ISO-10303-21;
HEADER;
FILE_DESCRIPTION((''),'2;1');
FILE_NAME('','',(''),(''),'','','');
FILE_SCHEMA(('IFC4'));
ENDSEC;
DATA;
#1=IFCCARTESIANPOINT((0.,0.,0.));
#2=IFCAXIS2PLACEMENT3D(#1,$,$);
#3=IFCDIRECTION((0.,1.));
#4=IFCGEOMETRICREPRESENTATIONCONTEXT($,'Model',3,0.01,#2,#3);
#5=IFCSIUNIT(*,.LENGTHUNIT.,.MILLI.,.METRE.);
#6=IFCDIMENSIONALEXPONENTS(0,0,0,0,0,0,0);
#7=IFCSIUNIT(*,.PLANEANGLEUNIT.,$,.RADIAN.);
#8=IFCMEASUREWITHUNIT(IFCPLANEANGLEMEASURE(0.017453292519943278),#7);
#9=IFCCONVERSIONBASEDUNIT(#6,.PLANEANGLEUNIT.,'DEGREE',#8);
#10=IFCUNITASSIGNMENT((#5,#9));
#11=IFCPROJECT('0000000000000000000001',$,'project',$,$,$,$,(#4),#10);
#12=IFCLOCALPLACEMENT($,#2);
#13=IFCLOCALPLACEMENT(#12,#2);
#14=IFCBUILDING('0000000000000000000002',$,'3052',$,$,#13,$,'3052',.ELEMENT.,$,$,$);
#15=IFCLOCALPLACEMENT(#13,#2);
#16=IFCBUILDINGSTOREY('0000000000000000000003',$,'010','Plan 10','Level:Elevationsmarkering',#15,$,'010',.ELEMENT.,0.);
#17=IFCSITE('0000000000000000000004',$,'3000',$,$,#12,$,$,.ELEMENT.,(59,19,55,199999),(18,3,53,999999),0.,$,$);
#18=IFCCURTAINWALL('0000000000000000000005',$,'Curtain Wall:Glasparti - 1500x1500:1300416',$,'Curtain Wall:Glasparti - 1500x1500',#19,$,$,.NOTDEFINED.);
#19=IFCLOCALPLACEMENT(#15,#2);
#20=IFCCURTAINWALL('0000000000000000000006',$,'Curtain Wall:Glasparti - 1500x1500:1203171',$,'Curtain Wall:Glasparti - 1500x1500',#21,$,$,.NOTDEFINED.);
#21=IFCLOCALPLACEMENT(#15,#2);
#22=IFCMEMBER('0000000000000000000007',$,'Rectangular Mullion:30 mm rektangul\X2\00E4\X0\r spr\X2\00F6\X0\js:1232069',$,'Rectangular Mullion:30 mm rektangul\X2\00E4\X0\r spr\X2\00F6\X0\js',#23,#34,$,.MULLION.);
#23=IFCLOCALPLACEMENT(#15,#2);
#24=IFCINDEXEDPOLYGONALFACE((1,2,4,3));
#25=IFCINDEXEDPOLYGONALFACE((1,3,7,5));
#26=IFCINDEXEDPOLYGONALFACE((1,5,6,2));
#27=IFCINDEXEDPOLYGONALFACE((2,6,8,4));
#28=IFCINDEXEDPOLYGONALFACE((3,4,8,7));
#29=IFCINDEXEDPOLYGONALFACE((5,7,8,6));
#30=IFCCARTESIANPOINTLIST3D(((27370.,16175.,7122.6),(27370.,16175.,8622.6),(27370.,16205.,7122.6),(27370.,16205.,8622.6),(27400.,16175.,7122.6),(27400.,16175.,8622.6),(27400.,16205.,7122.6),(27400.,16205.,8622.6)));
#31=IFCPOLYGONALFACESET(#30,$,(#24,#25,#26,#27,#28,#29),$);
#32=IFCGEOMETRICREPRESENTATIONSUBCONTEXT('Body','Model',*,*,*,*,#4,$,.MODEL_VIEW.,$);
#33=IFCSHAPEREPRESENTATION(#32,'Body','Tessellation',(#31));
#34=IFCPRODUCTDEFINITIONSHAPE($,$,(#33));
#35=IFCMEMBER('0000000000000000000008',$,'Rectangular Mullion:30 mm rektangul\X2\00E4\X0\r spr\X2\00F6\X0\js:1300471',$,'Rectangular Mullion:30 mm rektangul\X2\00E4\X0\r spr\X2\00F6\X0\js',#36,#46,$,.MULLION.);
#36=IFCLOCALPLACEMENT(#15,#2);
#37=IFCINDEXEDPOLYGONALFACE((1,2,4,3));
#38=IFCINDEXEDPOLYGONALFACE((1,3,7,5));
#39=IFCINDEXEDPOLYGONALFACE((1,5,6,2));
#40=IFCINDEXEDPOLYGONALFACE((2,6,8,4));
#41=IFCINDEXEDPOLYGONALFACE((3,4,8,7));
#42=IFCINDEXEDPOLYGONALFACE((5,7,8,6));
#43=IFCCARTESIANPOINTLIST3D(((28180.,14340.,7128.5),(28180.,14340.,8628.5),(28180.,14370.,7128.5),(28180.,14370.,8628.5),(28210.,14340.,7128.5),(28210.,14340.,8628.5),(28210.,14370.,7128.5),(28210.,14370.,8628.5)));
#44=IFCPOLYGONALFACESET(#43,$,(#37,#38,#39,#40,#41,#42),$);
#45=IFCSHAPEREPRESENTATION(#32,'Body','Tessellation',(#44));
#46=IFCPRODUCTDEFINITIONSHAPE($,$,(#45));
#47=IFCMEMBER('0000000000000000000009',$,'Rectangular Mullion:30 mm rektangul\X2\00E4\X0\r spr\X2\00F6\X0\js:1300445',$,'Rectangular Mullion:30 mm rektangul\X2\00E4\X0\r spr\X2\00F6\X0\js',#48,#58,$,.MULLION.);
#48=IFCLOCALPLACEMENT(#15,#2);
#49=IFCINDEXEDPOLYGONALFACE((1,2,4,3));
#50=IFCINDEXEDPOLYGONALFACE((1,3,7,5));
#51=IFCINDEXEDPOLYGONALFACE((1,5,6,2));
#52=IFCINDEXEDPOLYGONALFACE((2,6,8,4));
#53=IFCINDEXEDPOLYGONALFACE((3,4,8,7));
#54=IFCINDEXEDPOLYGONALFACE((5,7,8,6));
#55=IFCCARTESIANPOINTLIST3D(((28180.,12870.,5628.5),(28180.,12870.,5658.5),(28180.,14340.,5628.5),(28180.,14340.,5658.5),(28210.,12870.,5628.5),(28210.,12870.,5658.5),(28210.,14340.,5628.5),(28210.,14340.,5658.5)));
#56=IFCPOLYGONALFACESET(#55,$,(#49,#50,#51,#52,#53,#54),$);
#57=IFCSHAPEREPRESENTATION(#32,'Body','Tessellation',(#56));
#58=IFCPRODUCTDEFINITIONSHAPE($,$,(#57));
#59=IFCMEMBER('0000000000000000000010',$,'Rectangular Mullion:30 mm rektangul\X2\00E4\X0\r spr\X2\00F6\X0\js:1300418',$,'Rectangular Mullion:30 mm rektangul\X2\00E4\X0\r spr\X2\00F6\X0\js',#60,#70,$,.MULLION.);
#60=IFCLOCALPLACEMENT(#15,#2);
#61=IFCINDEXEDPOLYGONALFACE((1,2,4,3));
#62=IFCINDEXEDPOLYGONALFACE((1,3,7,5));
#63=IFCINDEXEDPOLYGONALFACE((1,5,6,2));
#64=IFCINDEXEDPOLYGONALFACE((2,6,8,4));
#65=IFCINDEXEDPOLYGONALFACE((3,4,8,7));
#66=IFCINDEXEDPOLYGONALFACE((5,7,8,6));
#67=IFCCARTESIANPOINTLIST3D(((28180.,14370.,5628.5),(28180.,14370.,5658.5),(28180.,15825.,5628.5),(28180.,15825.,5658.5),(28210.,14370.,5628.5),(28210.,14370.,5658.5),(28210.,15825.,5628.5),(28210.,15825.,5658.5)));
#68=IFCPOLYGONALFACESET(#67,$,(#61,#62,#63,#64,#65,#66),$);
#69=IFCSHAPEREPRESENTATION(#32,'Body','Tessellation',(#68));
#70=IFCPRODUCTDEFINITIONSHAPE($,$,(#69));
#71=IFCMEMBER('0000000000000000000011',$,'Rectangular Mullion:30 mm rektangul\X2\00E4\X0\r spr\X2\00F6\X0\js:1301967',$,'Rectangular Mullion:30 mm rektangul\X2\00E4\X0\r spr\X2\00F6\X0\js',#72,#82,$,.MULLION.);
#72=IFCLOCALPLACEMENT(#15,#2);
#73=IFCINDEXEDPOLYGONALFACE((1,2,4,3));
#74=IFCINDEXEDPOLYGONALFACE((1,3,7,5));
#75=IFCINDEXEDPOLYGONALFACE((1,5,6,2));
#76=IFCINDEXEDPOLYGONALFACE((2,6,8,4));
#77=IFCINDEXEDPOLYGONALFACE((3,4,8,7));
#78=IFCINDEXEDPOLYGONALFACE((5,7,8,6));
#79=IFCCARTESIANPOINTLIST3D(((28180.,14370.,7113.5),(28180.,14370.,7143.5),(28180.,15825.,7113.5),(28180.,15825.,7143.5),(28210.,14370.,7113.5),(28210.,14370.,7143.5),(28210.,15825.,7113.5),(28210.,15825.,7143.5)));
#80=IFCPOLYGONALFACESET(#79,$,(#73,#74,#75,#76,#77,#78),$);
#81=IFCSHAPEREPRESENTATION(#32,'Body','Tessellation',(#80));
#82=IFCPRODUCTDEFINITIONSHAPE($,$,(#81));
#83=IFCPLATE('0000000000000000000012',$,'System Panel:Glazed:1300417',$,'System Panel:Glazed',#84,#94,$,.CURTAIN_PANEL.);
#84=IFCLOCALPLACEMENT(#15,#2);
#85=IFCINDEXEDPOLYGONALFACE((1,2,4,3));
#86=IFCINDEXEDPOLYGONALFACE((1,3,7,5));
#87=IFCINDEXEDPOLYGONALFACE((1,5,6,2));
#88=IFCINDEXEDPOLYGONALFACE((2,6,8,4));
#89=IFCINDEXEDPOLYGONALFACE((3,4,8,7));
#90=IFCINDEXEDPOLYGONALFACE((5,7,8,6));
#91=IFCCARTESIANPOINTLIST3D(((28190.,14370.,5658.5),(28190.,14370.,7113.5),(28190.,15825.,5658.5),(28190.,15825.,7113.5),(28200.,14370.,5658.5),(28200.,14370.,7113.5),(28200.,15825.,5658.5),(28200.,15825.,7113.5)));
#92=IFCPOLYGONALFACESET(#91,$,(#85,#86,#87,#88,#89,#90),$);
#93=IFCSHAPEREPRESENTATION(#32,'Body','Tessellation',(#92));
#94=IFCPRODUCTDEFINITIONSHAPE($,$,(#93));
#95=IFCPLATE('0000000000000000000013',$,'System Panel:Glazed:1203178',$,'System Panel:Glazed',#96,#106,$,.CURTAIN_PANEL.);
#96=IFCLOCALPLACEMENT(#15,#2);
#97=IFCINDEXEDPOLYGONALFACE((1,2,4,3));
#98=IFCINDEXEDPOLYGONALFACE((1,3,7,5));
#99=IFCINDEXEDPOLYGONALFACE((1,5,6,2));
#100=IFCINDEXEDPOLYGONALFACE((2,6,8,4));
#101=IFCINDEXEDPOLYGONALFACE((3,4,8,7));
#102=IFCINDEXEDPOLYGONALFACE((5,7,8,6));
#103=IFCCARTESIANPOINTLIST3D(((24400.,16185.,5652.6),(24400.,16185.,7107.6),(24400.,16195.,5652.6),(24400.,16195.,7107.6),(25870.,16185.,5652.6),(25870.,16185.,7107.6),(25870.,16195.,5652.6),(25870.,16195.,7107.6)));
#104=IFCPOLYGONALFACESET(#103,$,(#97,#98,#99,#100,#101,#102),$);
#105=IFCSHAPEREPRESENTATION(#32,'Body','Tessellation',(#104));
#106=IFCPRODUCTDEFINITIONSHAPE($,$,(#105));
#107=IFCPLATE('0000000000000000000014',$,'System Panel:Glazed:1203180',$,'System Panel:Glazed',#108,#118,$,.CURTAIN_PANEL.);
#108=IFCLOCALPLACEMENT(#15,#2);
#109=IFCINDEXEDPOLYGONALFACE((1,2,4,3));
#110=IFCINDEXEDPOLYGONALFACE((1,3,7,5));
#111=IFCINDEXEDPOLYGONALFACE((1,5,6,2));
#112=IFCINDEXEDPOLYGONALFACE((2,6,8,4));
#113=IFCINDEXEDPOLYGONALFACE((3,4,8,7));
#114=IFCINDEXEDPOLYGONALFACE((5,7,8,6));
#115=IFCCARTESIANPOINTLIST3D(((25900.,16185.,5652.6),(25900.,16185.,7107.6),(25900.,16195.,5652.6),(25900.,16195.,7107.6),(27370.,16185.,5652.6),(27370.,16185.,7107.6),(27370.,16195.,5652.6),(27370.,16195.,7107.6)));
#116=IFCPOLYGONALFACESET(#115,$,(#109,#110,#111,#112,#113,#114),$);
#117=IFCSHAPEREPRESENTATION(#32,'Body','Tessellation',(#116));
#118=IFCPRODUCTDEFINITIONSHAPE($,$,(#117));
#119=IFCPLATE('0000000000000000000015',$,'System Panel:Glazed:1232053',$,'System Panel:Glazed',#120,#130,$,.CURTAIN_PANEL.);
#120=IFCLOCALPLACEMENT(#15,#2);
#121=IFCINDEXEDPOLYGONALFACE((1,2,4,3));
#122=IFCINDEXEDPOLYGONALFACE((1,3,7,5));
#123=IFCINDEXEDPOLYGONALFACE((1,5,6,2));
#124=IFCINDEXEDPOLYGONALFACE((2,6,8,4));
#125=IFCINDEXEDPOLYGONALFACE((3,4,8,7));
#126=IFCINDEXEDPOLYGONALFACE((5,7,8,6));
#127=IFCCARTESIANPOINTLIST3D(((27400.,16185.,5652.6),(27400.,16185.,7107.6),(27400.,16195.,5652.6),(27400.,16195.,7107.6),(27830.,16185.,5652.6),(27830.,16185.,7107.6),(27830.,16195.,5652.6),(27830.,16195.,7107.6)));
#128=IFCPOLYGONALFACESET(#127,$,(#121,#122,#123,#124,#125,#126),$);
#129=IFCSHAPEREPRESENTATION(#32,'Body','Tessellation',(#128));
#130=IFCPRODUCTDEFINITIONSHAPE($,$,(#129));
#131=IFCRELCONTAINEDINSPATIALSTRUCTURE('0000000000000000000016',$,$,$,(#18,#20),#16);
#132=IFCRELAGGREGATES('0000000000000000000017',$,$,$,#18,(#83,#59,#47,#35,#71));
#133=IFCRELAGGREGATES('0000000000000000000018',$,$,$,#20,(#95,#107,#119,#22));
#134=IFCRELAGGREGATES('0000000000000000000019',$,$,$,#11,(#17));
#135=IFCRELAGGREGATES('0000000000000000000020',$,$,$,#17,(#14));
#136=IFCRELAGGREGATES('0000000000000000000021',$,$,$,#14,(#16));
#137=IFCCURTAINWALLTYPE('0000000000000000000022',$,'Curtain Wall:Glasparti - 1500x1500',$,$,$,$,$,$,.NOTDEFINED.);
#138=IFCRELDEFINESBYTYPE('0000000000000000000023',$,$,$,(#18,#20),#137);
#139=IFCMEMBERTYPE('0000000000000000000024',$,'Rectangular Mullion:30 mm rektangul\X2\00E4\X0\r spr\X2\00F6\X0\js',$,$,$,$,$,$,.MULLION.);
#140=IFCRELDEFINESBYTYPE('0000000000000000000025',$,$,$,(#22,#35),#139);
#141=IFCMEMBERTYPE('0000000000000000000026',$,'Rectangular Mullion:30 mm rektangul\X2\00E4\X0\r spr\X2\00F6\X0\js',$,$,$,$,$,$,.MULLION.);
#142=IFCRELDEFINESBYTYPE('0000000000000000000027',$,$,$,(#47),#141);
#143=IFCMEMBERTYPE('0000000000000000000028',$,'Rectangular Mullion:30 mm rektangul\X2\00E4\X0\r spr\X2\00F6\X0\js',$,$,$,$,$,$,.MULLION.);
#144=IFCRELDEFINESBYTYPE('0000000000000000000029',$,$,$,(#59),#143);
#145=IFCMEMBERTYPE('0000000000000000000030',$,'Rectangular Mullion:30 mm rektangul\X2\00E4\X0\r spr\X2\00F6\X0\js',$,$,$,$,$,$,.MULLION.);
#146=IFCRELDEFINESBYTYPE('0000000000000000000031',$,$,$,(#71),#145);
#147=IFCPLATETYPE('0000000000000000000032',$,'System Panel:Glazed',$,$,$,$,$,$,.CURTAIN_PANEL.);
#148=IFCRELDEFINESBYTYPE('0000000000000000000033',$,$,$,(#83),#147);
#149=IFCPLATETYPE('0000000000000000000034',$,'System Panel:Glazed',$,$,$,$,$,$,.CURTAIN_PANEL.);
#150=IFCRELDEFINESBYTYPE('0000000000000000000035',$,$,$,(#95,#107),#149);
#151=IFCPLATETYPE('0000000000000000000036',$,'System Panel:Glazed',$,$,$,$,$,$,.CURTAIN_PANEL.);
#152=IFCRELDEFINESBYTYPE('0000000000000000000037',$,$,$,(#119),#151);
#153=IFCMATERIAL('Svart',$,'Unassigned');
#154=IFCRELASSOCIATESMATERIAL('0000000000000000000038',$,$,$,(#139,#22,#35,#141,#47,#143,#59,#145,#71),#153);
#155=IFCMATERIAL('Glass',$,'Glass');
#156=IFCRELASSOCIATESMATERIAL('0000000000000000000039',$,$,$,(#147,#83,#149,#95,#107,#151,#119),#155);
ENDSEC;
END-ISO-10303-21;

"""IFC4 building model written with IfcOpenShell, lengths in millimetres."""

from ifc_helpers import new_model, entity, si_unit, converted_unit, direction, frame, origin, place, context, subcontext, project, spatial, indexed_curve, outline, extrude, source, transform, mapped, material, type_object, type_shapes, element, aggregate, save


model = new_model("IFC4")

# Units and contexts
model_context = context("Model", 3, precision=0.01, world=origin(), true_north=direction((0.0, 1.0)))
body_context = subcontext(model_context, "Body", "Model", "MODEL_VIEW")
ifc_project = project(units=[si_unit("LENGTHUNIT", "METRE", prefix="MILLI"), converted_unit("PLANEANGLEUNIT", "DEGREE", entity("IfcPlaneAngleMeasure", 0.017453292519943278), si_unit("PLANEANGLEUNIT", "RADIAN"), dimensions=[0, 0, 0, 0, 0, 0, 0])], contexts=[model_context])

# Site, building, storey
site_placement = place(None, origin())
site = spatial("IfcSite", under=ifc_project, at=site_placement, Name="3000", CompositionType="ELEMENT", RefLatitude=(59, 19, 55, 199999), RefLongitude=(18, 3, 53, 999999), RefElevation=0.0)
building_placement = place(site_placement, origin())
building = spatial("IfcBuilding", under=site, at=building_placement, Name="3052", LongName="3052", CompositionType="ELEMENT")
storey_placement = place(building_placement, origin())
storey = spatial("IfcBuildingStorey", under=building, at=storey_placement, Name="010", Description="Plan 10", ObjectType="Level:Elevationsmarkering", LongName="010", CompositionType="ELEMENT", Elevation=0.0)

# Curtain wall
curtain_wall_type = type_object("IfcCurtainWallType", Name="Curtain Wall:Glasparti - 1500x1500", PredefinedType="NOTDEFINED")
curtain_wall_1_placement = place(storey_placement, origin())
curtain_wall_1 = element("IfcCurtainWall", 1, at=curtain_wall_1_placement, inside=storey, type_object=curtain_wall_type, Name="Curtain Wall:Glasparti - 1500x1500:1300416", ObjectType="Curtain Wall:Glasparti - 1500x1500", PredefinedType="NOTDEFINED")
ifc_material_1 = material(Name="Svart", Category="Unassigned")

# Curtain wall
curtain_wall_2_placement = place(storey_placement, origin())
curtain_wall_2 = element("IfcCurtainWall", 2, at=curtain_wall_2_placement, inside=storey, type_object=curtain_wall_type, Name="Curtain Wall:Glasparti - 1500x1500:1203171", ObjectType="Curtain Wall:Glasparti - 1500x1500", PredefinedType="NOTDEFINED")

# Members
member_type_1 = type_object("IfcMemberType", Name="Rectangular Mullion:30 mm rektangulär spröjs", PredefinedType="MULLION", material=ifc_material_1)
shared_shape_1 = source(origin(), body_context, "Body", "SweptSolid", [
    extrude(outline(indexed_curve([(-15.0, -15.0), (15.0, -15.0), (15.0, 15.0), (-15.0, 15.0), (-15.0, -15.0)], self_intersect=False)), frame((0.0, 0.0, -1500.0), z_axis=(0.0, 0.0, 1.0), x_axis=(-1.0, 0.0, 0.0)), (0.0, 0.0, 1.0), 1500.0),
])
type_shapes(member_type_1, [shared_shape_1])
member_1_placement = place(curtain_wall_2_placement, frame((27385.0, 16190.0, 7122.6), z_axis=(0.0, 0.0, -1.0), x_axis=(1.0, 0.0, 0.0)))
member_1 = element("IfcMember", 3, at=member_1_placement, type_object=member_type_1, material=ifc_material_1, Name="Rectangular Mullion:30 mm rektangulär spröjs:1232069", ObjectType="Rectangular Mullion:30 mm rektangulär spröjs", PredefinedType="MULLION", context=body_context, shape_type="MappedRepresentation", body=[
    mapped(shared_shape_1, transform((0.0, 0.0, 0.0), scale=1.0)),
])
member_2_placement = place(curtain_wall_1_placement, frame((28195.0, 14355.0, 7128.5), z_axis=(0.0, 0.0, -1.0), x_axis=(0.0, -1.0, 0.0)))
member_2 = element("IfcMember", 4, at=member_2_placement, type_object=member_type_1, material=ifc_material_1, Name="Rectangular Mullion:30 mm rektangulär spröjs:1300471", ObjectType="Rectangular Mullion:30 mm rektangulär spröjs", PredefinedType="MULLION", context=body_context, shape_type="MappedRepresentation", body=[
    mapped(shared_shape_1, transform((0.0, 0.0, 0.0), scale=1.0)),
])
member_type_2 = type_object("IfcMemberType", Name="Rectangular Mullion:30 mm rektangulär spröjs", PredefinedType="MULLION", material=ifc_material_1)
shared_shape_2 = source(origin(), body_context, "Body", "SweptSolid", [
    extrude(outline(indexed_curve([(-15.0, -15.0), (15.0, -15.0), (15.0, 15.0), (-15.0, 15.0), (-15.0, -15.0)], self_intersect=False)), frame((-15.0, 0.0, -1470.0), z_axis=(0.0, 0.0, 1.0), x_axis=(-1.0, 0.0, 0.0)), (0.0, 0.0, 1.0), 1470.0),
])
type_shapes(member_type_2, [shared_shape_2])
member_3_placement = place(curtain_wall_1_placement, frame((28195.0, 14340.0, 5628.5), z_axis=(0.0, 1.0, 0.0), x_axis=(0.0, 0.0, -1.0)))
member_3 = element("IfcMember", 5, at=member_3_placement, type_object=member_type_2, material=ifc_material_1, Name="Rectangular Mullion:30 mm rektangulär spröjs:1300445", ObjectType="Rectangular Mullion:30 mm rektangulär spröjs", PredefinedType="MULLION", context=body_context, shape_type="MappedRepresentation", body=[
    mapped(shared_shape_2, transform((0.0, 0.0, 0.0), scale=1.0)),
])
member_type_3 = type_object("IfcMemberType", Name="Rectangular Mullion:30 mm rektangulär spröjs", PredefinedType="MULLION", material=ifc_material_1)
shared_shape_3 = source(origin(), body_context, "Body", "SweptSolid", [
    extrude(outline(indexed_curve([(-15.0, -15.0), (15.0, -15.0), (15.0, 15.0), (-15.0, 15.0), (-15.0, -15.0)], self_intersect=False)), frame((-15.0, 0.0, -1455.0), z_axis=(0.0, 0.0, 1.0), x_axis=(-1.0, 0.0, 0.0)), (0.0, 0.0, 1.0), 1455.0),
])
type_shapes(member_type_3, [shared_shape_3])
member_4_placement = place(curtain_wall_1_placement, frame((28195.0, 15825.0, 5628.5), z_axis=(0.0, 1.0, 0.0), x_axis=(0.0, 0.0, -1.0)))
member_4 = element("IfcMember", 6, at=member_4_placement, type_object=member_type_3, material=ifc_material_1, Name="Rectangular Mullion:30 mm rektangulär spröjs:1300418", ObjectType="Rectangular Mullion:30 mm rektangulär spröjs", PredefinedType="MULLION", context=body_context, shape_type="MappedRepresentation", body=[
    mapped(shared_shape_3, transform((0.0, 0.0, 0.0), scale=1.0)),
])
member_type_4 = type_object("IfcMemberType", Name="Rectangular Mullion:30 mm rektangulär spröjs", PredefinedType="MULLION", material=ifc_material_1)
shared_shape_4 = source(origin(), body_context, "Body", "SweptSolid", [
    extrude(outline(indexed_curve([(-15.0, -15.0), (15.0, -15.0), (15.0, 15.0), (-15.0, 15.0), (-15.0, -15.0)], self_intersect=False)), frame((0.0, 0.0, -1455.0), z_axis=(0.0, 0.0, 1.0), x_axis=(-1.0, 0.0, 0.0)), (0.0, 0.0, 1.0), 1455.0),
])
type_shapes(member_type_4, [shared_shape_4])
member_5_placement = place(curtain_wall_1_placement, frame((28195.0, 14370.0, 7128.5), z_axis=(0.0, -1.0, 0.0), x_axis=(0.0, 0.0, 1.0)))
member_5 = element("IfcMember", 7, at=member_5_placement, type_object=member_type_4, material=ifc_material_1, Name="Rectangular Mullion:30 mm rektangulär spröjs:1301967", ObjectType="Rectangular Mullion:30 mm rektangulär spröjs", PredefinedType="MULLION", context=body_context, shape_type="MappedRepresentation", body=[
    mapped(shared_shape_4, transform((0.0, 0.0, 0.0), scale=1.0)),
])

# Plates
ifc_material_2 = material(Name="Glass", Category="Glass")
plate_type_1 = type_object("IfcPlateType", Name="System Panel:Glazed", PredefinedType="CURTAIN_PANEL", material=ifc_material_2)
shared_shape_5 = source(origin(), body_context, "Body", "SweptSolid", [
    extrude(outline(indexed_curve([(-5.0, -727.5), (5.0, -727.5), (5.0, 727.5), (-5.0, 727.5), (-5.0, -727.5)], self_intersect=False)), frame((0.0, 0.0, 0.0), z_axis=(0.0, 0.0, 1.0), x_axis=(0.0, 1.0, 0.0)), (0.0, 0.0, 1.0), 1455.0),
])
type_shapes(plate_type_1, [shared_shape_5])
plate_1_placement = place(curtain_wall_1_placement, frame((28195.0, 15097.5, 5658.5), z_axis=(0.0, 0.0, 1.0), x_axis=(0.0, -1.0, 0.0)))
plate_1 = element("IfcPlate", 8, at=plate_1_placement, type_object=plate_type_1, material=ifc_material_2, Name="System Panel:Glazed:1300417", ObjectType="System Panel:Glazed", PredefinedType="CURTAIN_PANEL", context=body_context, shape_type="MappedRepresentation", body=[
    mapped(shared_shape_5, transform((0.0, 0.0, 0.0), scale=1.0)),
])
aggregate(curtain_wall_1, [plate_1, member_4, member_3, member_2, member_5])
plate_type_2 = type_object("IfcPlateType", Name="System Panel:Glazed", PredefinedType="CURTAIN_PANEL", material=ifc_material_2)
shared_shape_6 = source(origin(), body_context, "Body", "SweptSolid", [
    extrude(outline(indexed_curve([(-5.0, -735.0), (5.0, -735.0), (5.0, 735.0), (-5.0, 735.0), (-5.0, -735.0)], self_intersect=False)), frame((0.0, 0.0, 0.0), z_axis=(0.0, 0.0, 1.0), x_axis=(0.0, 1.0, 0.0)), (0.0, 0.0, 1.0), 1455.0),
])
type_shapes(plate_type_2, [shared_shape_6])
plate_2_placement = place(curtain_wall_2_placement, frame((25135.0, 16190.0, 5652.6)))
plate_2 = element("IfcPlate", 9, at=plate_2_placement, type_object=plate_type_2, material=ifc_material_2, Name="System Panel:Glazed:1203178", ObjectType="System Panel:Glazed", PredefinedType="CURTAIN_PANEL", context=body_context, shape_type="MappedRepresentation", body=[
    mapped(shared_shape_6, transform((0.0, 0.0, 0.0), scale=1.0)),
])
plate_3_placement = place(curtain_wall_2_placement, frame((26635.0, 16190.0, 5652.6)))
plate_3 = element("IfcPlate", 10, at=plate_3_placement, type_object=plate_type_2, material=ifc_material_2, Name="System Panel:Glazed:1203180", ObjectType="System Panel:Glazed", PredefinedType="CURTAIN_PANEL", context=body_context, shape_type="MappedRepresentation", body=[
    mapped(shared_shape_6, transform((0.0, 0.0, 0.0), scale=1.0)),
])
plate_type_3 = type_object("IfcPlateType", Name="System Panel:Glazed", PredefinedType="CURTAIN_PANEL", material=ifc_material_2)
shared_shape_7 = source(origin(), body_context, "Body", "SweptSolid", [
    extrude(outline(indexed_curve([(-5.0, -215.0), (5.0, -215.0), (5.0, 215.0), (-5.0, 215.0), (-5.0, -215.0)], self_intersect=False)), frame((0.0, 0.0, 0.0), z_axis=(0.0, 0.0, 1.0), x_axis=(0.0, 1.0, 0.0)), (0.0, 0.0, 1.0), 1455.0),
])
type_shapes(plate_type_3, [shared_shape_7])
plate_4_placement = place(curtain_wall_2_placement, frame((27615.0, 16190.0, 5652.6)))
plate_4 = element("IfcPlate", 11, at=plate_4_placement, type_object=plate_type_3, material=ifc_material_2, Name="System Panel:Glazed:1232053", ObjectType="System Panel:Glazed", PredefinedType="CURTAIN_PANEL", context=body_context, shape_type="MappedRepresentation", body=[
    mapped(shared_shape_7, transform((0.0, 0.0, 0.0), scale=1.0)),
])
aggregate(curtain_wall_2, [plate_2, plate_3, plate_4, member_1])

save(model, "model.ifc")
